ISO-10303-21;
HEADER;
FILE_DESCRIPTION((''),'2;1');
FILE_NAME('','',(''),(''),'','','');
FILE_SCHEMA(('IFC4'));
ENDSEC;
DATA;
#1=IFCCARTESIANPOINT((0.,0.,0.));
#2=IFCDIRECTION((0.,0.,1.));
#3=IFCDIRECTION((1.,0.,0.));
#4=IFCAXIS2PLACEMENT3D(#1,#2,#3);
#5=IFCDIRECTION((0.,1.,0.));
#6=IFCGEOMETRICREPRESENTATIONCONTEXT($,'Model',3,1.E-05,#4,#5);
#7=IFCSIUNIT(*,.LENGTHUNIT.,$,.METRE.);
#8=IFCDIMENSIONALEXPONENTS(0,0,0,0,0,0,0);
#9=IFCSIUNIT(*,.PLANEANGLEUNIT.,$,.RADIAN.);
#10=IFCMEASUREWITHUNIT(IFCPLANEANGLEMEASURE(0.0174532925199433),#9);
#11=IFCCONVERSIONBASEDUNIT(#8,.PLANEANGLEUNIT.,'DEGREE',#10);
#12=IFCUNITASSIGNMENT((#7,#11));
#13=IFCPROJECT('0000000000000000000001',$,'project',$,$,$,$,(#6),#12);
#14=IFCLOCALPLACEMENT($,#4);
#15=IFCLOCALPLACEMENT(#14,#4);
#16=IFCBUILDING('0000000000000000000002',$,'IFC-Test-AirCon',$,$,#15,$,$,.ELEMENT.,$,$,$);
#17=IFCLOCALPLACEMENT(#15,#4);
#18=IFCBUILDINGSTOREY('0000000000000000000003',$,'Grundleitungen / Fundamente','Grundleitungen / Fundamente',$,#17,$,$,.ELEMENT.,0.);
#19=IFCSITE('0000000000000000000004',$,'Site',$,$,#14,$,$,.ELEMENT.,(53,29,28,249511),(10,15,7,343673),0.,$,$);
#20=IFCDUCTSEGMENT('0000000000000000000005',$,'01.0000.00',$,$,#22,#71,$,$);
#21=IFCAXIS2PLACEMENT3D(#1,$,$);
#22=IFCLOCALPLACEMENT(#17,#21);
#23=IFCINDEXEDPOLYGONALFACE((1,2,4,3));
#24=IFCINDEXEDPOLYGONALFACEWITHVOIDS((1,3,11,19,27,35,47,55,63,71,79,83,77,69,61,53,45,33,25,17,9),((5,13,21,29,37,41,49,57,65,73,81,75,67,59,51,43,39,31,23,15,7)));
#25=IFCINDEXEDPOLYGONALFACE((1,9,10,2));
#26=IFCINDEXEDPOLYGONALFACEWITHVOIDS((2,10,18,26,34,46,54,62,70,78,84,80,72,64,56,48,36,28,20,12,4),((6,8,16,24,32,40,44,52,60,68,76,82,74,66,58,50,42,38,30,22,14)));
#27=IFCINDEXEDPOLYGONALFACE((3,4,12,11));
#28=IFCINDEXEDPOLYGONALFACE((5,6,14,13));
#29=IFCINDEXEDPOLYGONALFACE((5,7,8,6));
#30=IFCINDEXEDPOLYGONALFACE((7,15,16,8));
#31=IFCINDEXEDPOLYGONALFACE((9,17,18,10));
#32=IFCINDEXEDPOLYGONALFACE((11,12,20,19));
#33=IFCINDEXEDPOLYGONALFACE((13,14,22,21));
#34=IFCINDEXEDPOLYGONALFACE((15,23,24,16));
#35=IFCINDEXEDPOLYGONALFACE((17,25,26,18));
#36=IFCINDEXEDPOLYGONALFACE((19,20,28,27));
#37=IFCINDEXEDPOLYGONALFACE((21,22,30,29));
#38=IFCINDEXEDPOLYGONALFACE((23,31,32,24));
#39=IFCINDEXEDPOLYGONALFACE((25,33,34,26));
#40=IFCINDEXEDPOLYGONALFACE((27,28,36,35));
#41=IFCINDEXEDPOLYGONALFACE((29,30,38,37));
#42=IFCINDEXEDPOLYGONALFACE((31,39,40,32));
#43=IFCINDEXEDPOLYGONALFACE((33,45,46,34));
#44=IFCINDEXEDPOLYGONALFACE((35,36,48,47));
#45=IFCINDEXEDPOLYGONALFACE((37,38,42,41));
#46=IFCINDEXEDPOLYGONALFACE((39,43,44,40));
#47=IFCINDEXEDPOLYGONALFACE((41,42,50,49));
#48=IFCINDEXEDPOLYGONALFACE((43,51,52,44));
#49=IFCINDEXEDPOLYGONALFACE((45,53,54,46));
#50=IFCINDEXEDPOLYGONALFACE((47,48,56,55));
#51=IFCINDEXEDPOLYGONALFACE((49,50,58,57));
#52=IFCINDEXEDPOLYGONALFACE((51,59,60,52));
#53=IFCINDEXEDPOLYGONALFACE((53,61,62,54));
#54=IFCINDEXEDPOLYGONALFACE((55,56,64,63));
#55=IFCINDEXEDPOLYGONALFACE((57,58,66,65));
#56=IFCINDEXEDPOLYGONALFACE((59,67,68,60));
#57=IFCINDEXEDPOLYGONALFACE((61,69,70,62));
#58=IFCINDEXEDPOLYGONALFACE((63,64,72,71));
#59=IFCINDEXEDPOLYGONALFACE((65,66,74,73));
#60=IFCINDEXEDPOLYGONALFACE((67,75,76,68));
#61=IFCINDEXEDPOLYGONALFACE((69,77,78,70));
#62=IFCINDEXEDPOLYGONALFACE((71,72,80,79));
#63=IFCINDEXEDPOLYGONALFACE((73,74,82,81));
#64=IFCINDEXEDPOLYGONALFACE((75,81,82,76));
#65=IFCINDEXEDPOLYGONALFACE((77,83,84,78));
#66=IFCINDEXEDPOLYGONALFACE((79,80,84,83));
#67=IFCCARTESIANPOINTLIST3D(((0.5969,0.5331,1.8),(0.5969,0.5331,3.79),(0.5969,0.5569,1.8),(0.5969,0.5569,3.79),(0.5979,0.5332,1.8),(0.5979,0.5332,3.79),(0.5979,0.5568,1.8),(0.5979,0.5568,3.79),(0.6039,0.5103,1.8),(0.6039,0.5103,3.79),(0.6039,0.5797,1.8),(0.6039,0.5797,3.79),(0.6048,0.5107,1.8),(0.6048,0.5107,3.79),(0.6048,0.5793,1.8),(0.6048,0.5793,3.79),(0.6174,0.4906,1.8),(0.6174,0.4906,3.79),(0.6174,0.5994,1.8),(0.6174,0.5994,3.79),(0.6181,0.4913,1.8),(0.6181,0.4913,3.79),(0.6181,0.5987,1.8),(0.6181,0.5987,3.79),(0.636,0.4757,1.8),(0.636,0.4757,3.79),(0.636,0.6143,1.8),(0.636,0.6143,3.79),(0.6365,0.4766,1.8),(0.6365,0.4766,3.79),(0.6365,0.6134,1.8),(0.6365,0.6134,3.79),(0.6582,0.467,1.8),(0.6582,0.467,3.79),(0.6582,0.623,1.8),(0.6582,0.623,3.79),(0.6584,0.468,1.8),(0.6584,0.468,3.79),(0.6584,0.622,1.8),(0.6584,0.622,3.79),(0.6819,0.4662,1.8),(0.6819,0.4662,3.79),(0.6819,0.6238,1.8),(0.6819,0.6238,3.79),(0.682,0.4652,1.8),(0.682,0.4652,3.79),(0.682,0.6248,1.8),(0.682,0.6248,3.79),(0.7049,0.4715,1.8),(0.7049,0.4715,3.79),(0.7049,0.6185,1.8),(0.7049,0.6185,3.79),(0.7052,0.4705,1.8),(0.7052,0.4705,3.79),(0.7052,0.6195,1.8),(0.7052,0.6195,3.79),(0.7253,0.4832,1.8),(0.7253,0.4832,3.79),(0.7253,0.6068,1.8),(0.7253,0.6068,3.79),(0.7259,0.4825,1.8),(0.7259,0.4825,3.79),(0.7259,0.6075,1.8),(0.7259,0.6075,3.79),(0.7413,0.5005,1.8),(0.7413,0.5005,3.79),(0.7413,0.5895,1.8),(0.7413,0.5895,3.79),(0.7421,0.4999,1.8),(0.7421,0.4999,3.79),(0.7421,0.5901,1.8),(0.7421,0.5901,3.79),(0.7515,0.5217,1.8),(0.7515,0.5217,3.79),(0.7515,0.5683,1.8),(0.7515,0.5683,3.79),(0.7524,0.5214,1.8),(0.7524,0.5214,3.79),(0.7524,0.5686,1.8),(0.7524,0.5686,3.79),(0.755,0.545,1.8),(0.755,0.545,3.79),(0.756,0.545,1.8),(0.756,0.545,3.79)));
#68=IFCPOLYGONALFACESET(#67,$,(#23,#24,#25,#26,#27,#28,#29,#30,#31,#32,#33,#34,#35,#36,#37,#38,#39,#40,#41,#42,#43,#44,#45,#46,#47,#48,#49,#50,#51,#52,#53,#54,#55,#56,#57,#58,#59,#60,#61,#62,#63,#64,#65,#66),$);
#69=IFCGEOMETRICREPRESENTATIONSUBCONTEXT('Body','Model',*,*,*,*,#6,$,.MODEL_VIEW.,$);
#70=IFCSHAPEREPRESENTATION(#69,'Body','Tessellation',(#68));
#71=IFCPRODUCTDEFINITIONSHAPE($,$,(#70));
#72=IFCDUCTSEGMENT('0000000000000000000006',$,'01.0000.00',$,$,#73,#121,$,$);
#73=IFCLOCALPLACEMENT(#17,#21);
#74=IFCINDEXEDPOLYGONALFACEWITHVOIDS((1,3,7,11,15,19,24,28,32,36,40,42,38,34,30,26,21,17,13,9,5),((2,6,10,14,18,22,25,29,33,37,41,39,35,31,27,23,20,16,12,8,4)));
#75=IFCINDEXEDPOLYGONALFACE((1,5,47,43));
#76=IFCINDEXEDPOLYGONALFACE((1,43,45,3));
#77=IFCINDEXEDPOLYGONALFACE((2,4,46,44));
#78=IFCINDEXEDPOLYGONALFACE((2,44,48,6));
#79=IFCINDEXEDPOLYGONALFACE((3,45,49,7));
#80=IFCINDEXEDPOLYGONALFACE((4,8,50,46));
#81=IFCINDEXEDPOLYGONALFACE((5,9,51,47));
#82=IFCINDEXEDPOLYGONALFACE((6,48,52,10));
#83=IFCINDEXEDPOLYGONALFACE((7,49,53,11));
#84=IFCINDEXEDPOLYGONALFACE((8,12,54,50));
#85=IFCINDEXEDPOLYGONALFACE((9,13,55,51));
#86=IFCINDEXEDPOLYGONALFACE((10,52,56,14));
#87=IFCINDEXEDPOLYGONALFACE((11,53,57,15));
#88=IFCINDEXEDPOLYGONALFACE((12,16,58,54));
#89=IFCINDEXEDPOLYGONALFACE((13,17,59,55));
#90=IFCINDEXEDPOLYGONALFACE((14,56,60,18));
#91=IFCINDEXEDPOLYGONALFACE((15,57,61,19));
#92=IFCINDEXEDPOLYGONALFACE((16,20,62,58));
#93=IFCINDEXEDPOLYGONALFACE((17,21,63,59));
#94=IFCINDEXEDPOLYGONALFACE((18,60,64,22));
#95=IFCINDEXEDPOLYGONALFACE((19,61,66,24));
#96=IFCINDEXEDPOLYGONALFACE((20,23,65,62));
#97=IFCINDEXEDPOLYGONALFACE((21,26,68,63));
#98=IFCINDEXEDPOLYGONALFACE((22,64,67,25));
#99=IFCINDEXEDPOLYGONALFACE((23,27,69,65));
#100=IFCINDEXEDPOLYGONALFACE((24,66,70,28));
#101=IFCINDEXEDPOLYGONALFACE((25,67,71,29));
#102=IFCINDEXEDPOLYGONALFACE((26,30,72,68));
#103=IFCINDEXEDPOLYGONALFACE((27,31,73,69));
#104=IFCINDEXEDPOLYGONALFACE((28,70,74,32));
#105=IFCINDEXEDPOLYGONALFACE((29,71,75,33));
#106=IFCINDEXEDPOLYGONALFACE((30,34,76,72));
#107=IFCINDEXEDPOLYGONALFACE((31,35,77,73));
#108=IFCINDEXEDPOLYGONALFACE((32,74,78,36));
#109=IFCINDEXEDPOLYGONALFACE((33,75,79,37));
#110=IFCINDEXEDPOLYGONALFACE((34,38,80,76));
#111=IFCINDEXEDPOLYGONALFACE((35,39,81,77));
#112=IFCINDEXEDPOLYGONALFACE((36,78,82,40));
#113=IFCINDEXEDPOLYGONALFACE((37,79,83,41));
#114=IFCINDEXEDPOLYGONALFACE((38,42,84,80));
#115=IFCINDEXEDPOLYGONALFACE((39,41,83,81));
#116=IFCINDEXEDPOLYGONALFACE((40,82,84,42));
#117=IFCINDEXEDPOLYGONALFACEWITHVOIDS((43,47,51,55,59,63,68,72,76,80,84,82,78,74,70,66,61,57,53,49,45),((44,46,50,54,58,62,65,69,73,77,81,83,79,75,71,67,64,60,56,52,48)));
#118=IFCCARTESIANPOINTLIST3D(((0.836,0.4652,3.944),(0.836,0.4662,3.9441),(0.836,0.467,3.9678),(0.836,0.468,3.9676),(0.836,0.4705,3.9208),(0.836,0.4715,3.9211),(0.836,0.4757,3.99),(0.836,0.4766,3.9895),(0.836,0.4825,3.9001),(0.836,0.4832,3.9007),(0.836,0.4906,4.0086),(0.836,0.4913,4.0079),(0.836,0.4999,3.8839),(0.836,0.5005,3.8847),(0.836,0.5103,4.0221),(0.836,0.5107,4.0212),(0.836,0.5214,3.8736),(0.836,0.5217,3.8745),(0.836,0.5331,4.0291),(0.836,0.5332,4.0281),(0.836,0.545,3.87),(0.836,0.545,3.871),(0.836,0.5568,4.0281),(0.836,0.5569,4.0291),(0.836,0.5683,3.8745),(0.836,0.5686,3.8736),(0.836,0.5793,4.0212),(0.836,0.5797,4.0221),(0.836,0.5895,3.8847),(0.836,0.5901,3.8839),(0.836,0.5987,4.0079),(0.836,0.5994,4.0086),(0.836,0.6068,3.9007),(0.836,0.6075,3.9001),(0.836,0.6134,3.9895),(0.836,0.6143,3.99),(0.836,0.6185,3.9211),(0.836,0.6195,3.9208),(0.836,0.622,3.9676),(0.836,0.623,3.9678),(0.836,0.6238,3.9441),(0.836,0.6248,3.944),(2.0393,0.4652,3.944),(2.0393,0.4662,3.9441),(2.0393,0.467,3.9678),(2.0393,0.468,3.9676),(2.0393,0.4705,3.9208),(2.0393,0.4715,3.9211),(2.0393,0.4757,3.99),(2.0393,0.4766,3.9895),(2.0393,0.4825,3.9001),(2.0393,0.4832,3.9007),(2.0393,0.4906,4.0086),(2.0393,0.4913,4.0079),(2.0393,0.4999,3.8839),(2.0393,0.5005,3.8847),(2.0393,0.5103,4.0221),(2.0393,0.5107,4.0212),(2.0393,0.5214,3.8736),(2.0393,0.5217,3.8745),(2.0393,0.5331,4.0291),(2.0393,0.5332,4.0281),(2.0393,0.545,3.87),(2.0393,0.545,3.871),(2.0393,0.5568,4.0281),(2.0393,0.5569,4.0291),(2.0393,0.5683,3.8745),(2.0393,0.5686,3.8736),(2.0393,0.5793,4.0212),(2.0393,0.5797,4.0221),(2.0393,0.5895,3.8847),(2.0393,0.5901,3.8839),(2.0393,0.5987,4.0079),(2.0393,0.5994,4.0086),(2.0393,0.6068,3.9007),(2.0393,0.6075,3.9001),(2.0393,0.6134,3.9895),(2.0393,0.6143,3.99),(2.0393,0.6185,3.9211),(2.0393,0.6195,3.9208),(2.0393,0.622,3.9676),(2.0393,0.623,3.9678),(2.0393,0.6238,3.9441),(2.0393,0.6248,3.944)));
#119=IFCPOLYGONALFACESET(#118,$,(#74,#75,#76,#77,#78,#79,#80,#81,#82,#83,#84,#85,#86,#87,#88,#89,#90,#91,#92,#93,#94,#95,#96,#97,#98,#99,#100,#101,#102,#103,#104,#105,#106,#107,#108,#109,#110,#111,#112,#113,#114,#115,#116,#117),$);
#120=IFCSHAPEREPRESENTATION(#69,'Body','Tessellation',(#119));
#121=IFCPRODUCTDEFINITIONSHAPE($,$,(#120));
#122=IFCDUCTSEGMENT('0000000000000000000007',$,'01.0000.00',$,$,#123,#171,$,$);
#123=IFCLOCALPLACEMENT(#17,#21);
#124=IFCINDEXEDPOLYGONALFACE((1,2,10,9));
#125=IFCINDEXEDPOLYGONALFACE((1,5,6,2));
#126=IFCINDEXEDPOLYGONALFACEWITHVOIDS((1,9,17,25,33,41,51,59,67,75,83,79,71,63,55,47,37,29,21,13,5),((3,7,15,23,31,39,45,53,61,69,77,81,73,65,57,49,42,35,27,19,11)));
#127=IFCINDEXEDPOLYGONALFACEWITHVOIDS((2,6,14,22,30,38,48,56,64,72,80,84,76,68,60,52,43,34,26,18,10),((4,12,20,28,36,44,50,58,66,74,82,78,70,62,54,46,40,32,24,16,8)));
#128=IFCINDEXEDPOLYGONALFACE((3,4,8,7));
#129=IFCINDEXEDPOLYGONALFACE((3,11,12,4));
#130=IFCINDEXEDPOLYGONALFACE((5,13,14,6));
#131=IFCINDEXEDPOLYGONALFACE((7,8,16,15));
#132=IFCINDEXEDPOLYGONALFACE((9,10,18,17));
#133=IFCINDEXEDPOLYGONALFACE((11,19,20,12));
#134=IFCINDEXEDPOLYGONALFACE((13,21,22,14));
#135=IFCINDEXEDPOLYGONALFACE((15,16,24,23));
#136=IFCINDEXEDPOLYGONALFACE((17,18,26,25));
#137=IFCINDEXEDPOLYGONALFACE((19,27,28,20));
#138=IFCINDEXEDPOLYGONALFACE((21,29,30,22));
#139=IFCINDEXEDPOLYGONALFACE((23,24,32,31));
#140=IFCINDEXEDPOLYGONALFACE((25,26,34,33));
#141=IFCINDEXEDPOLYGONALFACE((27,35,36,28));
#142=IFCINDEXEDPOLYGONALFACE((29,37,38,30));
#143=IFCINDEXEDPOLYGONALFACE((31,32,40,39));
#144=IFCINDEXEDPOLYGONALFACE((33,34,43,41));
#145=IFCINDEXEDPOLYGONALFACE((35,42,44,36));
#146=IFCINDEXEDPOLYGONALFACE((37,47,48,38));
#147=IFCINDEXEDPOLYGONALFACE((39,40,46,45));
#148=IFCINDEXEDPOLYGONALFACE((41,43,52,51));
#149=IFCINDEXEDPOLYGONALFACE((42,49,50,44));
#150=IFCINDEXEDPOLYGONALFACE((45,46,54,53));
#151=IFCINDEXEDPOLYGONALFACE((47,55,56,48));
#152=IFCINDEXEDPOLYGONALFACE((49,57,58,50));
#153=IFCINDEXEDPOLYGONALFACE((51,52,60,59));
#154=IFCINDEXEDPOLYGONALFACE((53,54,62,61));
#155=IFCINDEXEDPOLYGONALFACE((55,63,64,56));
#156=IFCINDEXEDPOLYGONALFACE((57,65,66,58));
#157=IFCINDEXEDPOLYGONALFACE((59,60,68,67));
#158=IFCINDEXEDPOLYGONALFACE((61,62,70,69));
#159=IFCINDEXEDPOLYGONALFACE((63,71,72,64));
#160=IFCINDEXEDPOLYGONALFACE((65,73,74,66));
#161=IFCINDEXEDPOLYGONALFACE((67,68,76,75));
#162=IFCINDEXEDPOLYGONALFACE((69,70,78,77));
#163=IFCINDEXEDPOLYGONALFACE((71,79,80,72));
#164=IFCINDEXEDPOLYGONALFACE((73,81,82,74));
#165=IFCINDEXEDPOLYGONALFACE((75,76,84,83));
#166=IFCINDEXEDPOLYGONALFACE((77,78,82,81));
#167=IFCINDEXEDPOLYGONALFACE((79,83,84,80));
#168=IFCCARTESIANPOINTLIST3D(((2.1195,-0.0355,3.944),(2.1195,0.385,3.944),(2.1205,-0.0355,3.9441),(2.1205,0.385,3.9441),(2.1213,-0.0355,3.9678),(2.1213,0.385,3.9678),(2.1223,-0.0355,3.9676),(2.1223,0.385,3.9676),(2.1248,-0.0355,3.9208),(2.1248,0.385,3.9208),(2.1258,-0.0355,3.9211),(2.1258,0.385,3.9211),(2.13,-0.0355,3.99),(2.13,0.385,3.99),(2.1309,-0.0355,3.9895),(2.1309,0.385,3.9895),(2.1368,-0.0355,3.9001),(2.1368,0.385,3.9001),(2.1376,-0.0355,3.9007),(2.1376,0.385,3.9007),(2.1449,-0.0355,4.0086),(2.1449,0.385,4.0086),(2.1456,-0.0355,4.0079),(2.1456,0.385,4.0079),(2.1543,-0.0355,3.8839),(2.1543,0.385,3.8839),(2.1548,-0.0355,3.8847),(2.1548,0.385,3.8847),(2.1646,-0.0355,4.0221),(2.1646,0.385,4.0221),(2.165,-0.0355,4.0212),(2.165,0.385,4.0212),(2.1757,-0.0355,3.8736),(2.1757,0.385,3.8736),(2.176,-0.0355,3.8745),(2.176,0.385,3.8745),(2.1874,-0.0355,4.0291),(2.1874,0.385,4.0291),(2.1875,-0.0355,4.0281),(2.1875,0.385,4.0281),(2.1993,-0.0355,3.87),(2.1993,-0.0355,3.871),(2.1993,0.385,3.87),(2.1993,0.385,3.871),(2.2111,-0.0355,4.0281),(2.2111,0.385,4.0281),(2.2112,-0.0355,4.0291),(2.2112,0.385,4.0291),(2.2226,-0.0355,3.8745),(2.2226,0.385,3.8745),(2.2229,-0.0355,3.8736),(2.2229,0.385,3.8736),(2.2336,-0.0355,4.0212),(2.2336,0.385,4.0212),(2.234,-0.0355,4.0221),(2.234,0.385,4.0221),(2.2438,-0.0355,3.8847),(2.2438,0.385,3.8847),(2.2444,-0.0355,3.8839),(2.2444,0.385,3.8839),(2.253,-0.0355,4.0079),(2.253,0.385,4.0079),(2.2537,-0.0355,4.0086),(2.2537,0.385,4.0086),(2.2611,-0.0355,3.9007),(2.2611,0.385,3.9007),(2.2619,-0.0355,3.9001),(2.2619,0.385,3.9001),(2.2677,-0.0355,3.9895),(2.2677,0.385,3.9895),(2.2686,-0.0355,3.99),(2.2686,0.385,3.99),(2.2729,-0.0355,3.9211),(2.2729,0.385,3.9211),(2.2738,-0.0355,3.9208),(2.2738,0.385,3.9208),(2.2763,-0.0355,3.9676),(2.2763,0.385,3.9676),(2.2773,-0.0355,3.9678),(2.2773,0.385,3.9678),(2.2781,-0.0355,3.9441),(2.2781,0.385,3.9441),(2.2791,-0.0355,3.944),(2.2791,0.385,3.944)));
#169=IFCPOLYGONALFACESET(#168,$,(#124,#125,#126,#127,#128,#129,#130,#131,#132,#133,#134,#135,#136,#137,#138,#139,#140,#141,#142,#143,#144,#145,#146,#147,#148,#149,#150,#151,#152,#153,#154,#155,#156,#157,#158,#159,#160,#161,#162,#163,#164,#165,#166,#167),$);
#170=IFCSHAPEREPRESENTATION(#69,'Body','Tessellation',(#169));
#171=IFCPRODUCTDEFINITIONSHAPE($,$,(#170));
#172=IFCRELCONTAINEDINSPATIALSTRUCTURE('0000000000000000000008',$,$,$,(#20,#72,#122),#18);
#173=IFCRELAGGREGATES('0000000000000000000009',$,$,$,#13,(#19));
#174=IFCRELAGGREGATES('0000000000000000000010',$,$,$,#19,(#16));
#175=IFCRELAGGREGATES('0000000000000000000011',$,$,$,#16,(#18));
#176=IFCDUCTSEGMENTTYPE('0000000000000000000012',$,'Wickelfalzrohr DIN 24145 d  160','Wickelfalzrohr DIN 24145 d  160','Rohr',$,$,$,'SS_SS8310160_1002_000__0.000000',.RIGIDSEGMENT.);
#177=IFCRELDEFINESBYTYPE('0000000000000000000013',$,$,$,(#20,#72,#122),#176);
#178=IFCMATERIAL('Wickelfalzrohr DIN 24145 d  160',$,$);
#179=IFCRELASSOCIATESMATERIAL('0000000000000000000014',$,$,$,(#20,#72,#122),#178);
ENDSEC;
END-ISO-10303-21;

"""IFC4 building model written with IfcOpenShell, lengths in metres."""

from ifc_helpers import new_model, entity, si_unit, converted_unit, direction, frame, origin_with_axes, origin_2d_with_axis, place, context, subcontext, project, spatial, hollow_circle, extrude, material, type_object, element, save


model = new_model("IFC4")

# Units and contexts
model_context = context("Model", 3, precision=1e-05, world=origin_with_axes(), true_north=direction((0.0, 1.0, 0.0)))
body_context = subcontext(model_context, "Body", "Model", "MODEL_VIEW")
ifc_project = project(units=[si_unit("LENGTHUNIT", "METRE"), converted_unit("PLANEANGLEUNIT", "DEGREE", entity("IfcPlaneAngleMeasure", 0.0174532925199433), si_unit("PLANEANGLEUNIT", "RADIAN"), dimensions=[0, 0, 0, 0, 0, 0, 0])], contexts=[model_context])

# Site, building, storey
site_placement = place(None, origin_with_axes())
site = spatial("IfcSite", under=ifc_project, at=site_placement, Name="Site", CompositionType="ELEMENT", RefLatitude=(53, 29, 28, 249511), RefLongitude=(10, 15, 7, 343673), RefElevation=0.0)
building_placement = place(site_placement, origin_with_axes())
building = spatial("IfcBuilding", under=site, at=building_placement, Name="IFC-Test-AirCon", CompositionType="ELEMENT")
storey_placement = place(building_placement, origin_with_axes())
storey = spatial("IfcBuildingStorey", under=building, at=storey_placement, Name="Grundleitungen / Fundamente", Description="Grundleitungen / Fundamente", CompositionType="ELEMENT", Elevation=0.0)

# Duct segments
ifc_material_1 = material(Name="Wickelfalzrohr DIN 24145 d  160")
duct_segment_type_1 = type_object("IfcDuctSegmentType", Name="Wickelfalzrohr DIN 24145 d  160", Description="Wickelfalzrohr DIN 24145 d  160", ApplicableOccurrence="Rohr", ElementType="SS_SS8310160_1002_000__0.000000", PredefinedType="RIGIDSEGMENT")
duct_segment_1_placement = place(storey_placement, frame((0.676, 0.545, 1.8), z_axis=(-1.0, 0.0, 0.0), x_axis=(0.0, 0.0, 1.0)))
element("IfcDuctSegment", 1, at=duct_segment_1_placement, inside=storey, type_object=duct_segment_type_1, material=ifc_material_1, Name="01.0000.00", context=body_context, shape_type="SweptSolid", body=[
    extrude(hollow_circle(Radius=0.08, WallThickness=0.001, at=origin_2d_with_axis()), frame((0.0, 0.0, 0.0), z_axis=(1.0, 0.0, 0.0), x_axis=(0.0, 0.0, -1.0)), (0.0, 0.0, 1.0), 1.99),
])
duct_segment_2_placement = place(storey_placement, frame((0.836, 0.545, 3.95), z_axis=(0.0, 0.0, 1.0), x_axis=(1.0, 0.0, 0.0)))
element("IfcDuctSegment", 2, at=duct_segment_2_placement, inside=storey, type_object=duct_segment_type_1, material=ifc_material_1, Name="01.0000.00", context=body_context, shape_type="SweptSolid", body=[
    extrude(hollow_circle(Radius=0.08, WallThickness=0.001, at=origin_2d_with_axis()), frame((0.0, 0.0, 0.0), z_axis=(1.0, 0.0, 0.0), x_axis=(0.0, 0.0, -1.0)), (0.0, 0.0, 1.0), 1.2033),
])
duct_segment_3_placement = place(storey_placement, frame((2.1993, 0.385, 3.95), z_axis=(0.0, 0.0, 1.0), x_axis=(0.0, -1.0, 0.0)))
element("IfcDuctSegment", 3, at=duct_segment_3_placement, inside=storey, type_object=duct_segment_type_1, material=ifc_material_1, Name="01.0000.00", context=body_context, shape_type="SweptSolid", body=[
    extrude(hollow_circle(Radius=0.08, WallThickness=0.001, at=origin_2d_with_axis()), frame((0.0, 0.0, 0.0), z_axis=(1.0, 0.0, 0.0), x_axis=(0.0, 0.0, -1.0)), (0.0, 0.0, 1.0), 0.4205),
])

save(model, "model.ifc")
